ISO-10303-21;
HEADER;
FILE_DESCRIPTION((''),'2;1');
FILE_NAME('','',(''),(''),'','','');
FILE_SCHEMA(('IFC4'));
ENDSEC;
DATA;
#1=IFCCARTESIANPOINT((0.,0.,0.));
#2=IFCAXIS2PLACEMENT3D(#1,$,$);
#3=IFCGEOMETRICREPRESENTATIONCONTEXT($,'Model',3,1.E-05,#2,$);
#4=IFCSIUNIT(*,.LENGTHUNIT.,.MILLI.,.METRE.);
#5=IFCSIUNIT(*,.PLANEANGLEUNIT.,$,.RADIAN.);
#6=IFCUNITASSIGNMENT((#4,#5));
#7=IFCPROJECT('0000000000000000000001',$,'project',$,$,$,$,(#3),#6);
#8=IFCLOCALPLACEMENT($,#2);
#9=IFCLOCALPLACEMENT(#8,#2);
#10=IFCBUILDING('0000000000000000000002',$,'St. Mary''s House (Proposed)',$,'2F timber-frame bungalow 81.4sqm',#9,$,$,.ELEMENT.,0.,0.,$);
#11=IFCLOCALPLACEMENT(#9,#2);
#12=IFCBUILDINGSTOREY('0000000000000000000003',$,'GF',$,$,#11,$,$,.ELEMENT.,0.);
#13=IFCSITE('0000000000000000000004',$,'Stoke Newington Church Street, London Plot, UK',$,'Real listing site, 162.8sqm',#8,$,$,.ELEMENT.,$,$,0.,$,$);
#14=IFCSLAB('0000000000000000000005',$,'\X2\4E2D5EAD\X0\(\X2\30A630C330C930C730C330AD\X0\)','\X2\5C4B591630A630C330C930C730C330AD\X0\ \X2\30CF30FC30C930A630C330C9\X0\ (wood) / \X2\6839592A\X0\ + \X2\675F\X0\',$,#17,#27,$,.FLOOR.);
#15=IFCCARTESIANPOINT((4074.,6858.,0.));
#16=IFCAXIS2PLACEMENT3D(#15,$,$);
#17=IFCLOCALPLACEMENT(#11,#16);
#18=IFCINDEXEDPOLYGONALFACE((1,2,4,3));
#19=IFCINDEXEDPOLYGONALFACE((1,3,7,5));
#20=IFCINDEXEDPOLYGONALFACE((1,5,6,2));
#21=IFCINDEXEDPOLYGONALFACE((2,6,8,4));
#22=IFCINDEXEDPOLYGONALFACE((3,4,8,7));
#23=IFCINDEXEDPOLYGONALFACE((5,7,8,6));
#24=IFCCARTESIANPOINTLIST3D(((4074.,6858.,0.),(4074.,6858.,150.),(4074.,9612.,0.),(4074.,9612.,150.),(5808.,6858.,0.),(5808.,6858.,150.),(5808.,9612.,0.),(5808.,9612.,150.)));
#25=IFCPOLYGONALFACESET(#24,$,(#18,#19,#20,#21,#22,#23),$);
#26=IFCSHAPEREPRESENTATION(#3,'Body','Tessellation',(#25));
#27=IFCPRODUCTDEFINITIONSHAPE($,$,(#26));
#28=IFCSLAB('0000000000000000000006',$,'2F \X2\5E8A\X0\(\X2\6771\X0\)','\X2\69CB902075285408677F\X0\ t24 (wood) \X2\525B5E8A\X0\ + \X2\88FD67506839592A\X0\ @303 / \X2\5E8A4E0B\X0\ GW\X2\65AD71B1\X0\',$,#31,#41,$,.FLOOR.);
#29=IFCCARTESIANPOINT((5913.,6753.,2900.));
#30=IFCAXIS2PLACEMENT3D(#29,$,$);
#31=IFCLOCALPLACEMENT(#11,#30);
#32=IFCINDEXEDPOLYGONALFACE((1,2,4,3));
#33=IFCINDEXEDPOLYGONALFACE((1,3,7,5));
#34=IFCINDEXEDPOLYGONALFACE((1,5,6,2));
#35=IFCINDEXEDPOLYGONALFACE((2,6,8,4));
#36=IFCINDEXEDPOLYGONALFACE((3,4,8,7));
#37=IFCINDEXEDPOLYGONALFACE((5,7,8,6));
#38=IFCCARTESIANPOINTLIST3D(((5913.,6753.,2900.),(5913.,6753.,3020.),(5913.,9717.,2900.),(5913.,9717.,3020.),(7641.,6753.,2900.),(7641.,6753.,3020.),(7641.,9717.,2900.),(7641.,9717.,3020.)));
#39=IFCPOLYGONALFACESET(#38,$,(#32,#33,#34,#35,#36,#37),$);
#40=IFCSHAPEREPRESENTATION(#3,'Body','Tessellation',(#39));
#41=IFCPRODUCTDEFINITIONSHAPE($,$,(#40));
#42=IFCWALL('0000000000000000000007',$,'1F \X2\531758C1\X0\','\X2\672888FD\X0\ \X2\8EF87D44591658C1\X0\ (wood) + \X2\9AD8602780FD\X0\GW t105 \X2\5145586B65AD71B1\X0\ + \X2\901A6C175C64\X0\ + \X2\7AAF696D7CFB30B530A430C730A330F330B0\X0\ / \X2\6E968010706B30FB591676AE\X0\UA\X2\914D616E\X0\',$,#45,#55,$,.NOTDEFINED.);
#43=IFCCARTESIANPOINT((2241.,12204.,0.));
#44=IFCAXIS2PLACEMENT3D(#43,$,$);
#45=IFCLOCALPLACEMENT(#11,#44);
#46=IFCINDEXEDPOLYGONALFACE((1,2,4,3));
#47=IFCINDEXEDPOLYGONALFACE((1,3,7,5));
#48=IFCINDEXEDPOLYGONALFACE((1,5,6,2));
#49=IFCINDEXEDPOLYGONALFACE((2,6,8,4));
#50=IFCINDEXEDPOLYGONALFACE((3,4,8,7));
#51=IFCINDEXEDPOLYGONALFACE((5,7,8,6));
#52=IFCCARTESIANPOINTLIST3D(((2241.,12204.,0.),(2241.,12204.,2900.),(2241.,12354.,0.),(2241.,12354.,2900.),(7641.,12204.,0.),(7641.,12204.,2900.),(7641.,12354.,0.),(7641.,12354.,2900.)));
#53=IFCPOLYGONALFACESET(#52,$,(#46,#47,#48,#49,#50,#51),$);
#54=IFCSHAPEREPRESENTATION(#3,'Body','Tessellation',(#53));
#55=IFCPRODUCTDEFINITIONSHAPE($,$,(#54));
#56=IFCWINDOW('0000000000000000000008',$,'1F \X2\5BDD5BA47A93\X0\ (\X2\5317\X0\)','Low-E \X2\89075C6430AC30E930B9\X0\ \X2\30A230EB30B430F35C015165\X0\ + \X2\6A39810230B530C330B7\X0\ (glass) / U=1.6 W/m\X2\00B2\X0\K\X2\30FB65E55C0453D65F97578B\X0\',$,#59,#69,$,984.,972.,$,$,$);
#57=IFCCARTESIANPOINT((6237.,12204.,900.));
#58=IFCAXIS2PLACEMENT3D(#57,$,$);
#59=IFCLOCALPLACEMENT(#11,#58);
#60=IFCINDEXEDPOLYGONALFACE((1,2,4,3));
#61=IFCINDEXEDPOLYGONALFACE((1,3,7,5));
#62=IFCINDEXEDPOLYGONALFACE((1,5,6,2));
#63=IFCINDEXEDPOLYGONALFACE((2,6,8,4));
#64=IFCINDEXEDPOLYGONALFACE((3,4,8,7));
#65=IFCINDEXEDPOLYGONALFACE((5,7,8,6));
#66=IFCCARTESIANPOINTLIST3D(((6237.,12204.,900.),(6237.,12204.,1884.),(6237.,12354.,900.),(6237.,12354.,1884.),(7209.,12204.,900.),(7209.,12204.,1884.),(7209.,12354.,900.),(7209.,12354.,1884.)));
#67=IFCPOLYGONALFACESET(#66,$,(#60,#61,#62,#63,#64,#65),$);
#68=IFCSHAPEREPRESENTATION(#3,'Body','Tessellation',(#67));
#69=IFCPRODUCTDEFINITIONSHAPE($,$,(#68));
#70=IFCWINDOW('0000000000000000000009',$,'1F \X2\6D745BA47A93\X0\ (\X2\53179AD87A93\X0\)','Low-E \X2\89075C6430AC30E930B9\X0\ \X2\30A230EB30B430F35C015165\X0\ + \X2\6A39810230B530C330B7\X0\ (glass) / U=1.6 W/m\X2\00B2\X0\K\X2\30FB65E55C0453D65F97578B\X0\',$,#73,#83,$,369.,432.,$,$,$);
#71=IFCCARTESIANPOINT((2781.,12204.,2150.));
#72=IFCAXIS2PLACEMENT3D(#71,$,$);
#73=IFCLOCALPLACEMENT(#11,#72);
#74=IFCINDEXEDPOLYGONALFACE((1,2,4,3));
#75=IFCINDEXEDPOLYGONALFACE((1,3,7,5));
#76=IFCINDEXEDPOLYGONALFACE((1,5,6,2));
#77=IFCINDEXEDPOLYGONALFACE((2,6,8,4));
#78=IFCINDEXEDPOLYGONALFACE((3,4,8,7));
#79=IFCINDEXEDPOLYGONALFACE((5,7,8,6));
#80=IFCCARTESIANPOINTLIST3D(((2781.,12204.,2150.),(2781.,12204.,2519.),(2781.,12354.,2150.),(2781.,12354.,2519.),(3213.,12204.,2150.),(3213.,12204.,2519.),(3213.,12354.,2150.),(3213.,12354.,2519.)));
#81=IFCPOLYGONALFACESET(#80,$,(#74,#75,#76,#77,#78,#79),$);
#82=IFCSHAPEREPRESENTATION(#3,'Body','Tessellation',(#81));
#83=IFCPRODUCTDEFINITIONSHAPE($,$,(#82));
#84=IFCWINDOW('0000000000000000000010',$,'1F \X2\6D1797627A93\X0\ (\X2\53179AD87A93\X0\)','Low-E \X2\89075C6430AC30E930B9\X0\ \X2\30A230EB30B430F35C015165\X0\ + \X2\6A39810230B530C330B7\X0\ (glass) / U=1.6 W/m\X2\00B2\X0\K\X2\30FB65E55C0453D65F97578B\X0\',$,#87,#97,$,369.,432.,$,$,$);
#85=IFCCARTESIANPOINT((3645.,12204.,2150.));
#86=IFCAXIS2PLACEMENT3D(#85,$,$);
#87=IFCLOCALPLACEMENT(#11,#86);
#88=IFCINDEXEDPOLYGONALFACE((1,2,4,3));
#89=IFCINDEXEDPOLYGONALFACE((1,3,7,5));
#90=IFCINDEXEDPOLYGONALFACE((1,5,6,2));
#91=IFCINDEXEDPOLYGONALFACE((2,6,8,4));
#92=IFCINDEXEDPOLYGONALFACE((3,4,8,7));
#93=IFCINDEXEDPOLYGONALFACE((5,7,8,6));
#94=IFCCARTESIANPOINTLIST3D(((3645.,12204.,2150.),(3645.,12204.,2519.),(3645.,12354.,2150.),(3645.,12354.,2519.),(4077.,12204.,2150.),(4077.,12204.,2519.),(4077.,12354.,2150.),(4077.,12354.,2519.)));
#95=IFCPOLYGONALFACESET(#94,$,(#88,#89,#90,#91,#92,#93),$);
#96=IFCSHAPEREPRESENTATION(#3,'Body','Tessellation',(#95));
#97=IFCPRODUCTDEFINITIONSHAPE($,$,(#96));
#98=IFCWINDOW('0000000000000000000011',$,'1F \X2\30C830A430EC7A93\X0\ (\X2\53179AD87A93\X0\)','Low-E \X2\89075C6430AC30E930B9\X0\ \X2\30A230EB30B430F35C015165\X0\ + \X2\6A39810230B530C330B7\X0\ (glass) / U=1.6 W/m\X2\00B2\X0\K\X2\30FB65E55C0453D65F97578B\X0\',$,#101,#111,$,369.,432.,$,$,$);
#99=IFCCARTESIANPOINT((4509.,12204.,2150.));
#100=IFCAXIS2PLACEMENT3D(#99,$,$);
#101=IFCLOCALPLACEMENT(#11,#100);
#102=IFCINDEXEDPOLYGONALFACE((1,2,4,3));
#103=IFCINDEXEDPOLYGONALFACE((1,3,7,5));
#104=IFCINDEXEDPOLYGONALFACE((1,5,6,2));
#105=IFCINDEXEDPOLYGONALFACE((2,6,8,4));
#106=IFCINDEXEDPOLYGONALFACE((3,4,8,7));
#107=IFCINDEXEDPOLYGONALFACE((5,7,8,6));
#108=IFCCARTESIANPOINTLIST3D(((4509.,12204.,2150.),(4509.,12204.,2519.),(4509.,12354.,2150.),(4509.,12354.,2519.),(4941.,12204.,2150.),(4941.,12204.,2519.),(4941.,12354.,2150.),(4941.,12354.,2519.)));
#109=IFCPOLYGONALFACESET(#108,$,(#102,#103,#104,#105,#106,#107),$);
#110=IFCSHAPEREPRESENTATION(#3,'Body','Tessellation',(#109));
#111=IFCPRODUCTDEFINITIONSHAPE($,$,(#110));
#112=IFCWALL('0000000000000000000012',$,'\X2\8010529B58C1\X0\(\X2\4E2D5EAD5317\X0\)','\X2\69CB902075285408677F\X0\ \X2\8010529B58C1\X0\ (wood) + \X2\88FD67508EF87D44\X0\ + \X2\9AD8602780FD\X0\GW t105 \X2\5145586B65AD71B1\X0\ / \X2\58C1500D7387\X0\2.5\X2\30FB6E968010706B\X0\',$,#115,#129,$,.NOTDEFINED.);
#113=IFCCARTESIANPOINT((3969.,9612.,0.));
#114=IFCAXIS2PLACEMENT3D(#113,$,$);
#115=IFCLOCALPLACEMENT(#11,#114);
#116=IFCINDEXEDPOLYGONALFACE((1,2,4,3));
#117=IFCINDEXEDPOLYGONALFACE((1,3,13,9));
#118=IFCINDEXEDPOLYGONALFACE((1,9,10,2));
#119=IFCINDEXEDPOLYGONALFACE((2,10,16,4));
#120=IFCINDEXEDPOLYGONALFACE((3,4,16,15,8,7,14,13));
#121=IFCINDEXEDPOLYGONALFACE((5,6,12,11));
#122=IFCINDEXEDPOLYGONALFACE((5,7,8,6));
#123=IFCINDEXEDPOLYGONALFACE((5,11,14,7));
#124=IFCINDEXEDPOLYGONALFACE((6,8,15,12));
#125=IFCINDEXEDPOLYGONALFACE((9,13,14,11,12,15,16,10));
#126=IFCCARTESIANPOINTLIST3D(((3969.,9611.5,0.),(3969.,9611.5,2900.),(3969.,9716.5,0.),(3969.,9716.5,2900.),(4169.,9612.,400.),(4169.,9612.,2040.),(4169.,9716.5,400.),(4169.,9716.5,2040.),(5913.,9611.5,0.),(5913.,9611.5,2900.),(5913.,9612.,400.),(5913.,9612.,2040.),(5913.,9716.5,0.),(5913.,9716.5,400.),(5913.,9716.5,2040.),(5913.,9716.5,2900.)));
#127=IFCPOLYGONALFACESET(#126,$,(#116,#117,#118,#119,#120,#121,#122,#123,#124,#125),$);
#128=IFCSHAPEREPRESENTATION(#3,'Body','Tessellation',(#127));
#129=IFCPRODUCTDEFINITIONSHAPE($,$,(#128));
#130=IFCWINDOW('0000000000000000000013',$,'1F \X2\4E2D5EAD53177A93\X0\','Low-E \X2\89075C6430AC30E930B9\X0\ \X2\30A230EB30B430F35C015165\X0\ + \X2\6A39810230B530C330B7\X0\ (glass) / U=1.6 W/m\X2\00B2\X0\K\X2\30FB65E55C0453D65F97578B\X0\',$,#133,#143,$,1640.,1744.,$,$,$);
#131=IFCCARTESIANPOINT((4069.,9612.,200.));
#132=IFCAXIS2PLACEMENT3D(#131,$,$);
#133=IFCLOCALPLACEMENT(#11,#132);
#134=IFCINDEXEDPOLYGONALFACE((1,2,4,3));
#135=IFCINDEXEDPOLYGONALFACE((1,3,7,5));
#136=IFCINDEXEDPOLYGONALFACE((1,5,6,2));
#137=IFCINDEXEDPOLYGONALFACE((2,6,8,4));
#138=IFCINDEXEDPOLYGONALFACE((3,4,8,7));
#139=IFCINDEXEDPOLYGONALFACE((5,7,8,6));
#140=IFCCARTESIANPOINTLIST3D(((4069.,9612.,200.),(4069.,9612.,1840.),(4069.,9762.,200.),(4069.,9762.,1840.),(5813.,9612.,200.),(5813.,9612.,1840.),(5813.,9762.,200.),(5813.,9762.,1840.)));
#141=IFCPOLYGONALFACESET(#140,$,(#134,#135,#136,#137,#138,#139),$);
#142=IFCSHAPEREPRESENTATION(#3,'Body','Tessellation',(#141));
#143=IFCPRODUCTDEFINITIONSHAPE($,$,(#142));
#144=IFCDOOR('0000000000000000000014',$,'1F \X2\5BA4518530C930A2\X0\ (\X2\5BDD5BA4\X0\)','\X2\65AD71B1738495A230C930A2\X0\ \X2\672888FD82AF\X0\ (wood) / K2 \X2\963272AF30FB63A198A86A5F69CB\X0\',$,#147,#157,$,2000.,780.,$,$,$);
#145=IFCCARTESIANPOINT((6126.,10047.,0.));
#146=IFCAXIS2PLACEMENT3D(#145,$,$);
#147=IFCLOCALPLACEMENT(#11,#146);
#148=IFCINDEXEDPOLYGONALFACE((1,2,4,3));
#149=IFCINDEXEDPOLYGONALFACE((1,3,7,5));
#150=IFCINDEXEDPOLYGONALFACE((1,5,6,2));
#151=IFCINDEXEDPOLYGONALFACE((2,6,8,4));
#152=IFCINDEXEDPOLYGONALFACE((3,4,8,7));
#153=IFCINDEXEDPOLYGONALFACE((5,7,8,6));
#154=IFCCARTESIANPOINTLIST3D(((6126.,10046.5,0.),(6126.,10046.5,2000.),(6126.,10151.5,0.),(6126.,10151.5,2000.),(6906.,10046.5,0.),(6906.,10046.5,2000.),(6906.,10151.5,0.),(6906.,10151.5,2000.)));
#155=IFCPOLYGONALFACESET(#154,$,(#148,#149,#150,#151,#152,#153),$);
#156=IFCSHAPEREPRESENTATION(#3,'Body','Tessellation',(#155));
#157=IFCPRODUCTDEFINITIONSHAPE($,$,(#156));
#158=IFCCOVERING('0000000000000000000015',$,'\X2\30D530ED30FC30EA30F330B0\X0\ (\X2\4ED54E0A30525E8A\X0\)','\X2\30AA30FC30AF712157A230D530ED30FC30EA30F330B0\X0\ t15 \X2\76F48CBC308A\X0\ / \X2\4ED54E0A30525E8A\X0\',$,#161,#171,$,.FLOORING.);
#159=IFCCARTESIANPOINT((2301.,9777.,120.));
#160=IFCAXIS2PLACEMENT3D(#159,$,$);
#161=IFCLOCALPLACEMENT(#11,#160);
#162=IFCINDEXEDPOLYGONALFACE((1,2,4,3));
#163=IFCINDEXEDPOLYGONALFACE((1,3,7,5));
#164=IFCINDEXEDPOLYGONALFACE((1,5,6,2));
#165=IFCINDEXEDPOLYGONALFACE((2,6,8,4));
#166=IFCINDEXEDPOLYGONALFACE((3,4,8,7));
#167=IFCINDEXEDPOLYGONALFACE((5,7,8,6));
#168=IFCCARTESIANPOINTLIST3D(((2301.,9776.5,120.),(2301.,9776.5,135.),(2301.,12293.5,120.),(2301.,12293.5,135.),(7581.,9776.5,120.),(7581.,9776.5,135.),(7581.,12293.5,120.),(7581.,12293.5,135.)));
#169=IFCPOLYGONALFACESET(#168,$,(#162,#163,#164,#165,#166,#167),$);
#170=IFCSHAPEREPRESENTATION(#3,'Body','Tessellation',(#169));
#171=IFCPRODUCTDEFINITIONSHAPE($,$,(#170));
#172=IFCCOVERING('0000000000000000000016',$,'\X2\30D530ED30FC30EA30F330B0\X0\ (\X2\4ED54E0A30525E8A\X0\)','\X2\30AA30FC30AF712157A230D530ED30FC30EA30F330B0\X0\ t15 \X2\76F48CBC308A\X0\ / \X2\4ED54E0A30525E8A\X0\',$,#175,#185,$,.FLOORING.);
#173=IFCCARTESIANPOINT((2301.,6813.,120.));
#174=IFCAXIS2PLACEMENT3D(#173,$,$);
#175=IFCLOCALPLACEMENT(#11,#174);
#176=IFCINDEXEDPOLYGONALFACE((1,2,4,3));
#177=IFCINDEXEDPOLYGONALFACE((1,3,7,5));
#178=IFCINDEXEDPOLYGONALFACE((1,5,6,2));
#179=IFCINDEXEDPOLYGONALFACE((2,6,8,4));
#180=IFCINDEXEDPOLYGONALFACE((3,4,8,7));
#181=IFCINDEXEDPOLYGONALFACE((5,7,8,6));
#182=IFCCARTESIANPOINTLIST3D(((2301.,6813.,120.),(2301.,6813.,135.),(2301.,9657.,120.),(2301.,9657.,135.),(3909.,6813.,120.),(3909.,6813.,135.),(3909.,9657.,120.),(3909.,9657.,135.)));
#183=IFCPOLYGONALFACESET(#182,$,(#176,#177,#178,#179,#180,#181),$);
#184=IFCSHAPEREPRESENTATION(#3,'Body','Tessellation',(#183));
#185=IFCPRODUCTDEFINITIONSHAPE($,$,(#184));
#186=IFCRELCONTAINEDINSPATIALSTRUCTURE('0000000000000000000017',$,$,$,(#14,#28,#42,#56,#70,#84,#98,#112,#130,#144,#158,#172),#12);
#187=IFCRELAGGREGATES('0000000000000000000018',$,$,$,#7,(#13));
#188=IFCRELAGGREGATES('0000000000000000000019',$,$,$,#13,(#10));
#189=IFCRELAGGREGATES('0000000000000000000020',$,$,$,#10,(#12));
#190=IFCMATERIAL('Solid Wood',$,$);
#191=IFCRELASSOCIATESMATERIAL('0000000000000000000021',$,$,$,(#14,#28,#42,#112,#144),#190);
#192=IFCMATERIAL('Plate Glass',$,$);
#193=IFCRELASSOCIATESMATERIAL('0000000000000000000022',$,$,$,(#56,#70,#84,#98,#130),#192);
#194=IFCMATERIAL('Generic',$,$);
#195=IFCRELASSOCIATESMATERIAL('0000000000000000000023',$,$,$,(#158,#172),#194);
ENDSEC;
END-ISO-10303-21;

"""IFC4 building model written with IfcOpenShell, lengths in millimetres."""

from ifc_helpers import new_model, si_unit, frame, frame_2d, origin, place, context, project, spatial, rectangle, extrude, material, element, fill, save


model = new_model("IFC4")

# Units and contexts
model_context = context("Model", 3, precision=1e-05, world=origin())
ifc_project = project(units=[si_unit("LENGTHUNIT", "METRE", prefix="MILLI"), si_unit("PLANEANGLEUNIT", "RADIAN")], contexts=[model_context])

# Site, building, storey
site_placement = place(None, origin())
site = spatial("IfcSite", under=ifc_project, at=site_placement, Name="Stoke Newington Church Street, London Plot, UK", ObjectType="Real listing site, 162.8sqm", CompositionType="ELEMENT", RefElevation=0.0)
building_placement = place(site_placement, origin())
building = spatial("IfcBuilding", under=site, at=building_placement, Name="St. Mary's House (Proposed)", ObjectType="2F timber-frame bungalow 81.4sqm", CompositionType="ELEMENT", ElevationOfRefHeight=0.0, ElevationOfTerrain=0.0)
storey_placement = place(building_placement, origin())
storey = spatial("IfcBuildingStorey", under=building, at=storey_placement, Name="GF", CompositionType="ELEMENT", Elevation=0.0)

# Slabs
ifc_material_1 = material(Name="Solid Wood")
slab_1_placement = place(storey_placement, frame((4074.0, 6858.0, 0.0)))
element("IfcSlab", 1, at=slab_1_placement, inside=storey, material=ifc_material_1, Name="中庭(ウッドデッキ)", Description="屋外ウッドデッキ ハードウッド (wood) / 根太 + 束", PredefinedType="FLOOR", context=model_context, shape_type="SweptSolid", body=[
    extrude(rectangle(XDim=1734.0, YDim=2754.0, at=frame_2d((867.0, 1377.0))), frame((4074.0, 6858.0, 0.0)), (0.0, 0.0, 1.0), 150.0),
])
slab_2_placement = place(storey_placement, frame((5913.0, 6753.0, 2900.0)))
element("IfcSlab", 2, at=slab_2_placement, inside=storey, material=ifc_material_1, Name="2F 床(東)", Description="構造用合板 t24 (wood) 剛床 + 製材根太 @303 / 床下 GW断熱", PredefinedType="FLOOR", context=model_context, shape_type="SweptSolid", body=[
    extrude(rectangle(XDim=1728.0, YDim=2964.0, at=frame_2d((864.0, 1482.0))), frame((5913.0, 6753.0, 2900.0)), (0.0, 0.0, 1.0), 120.0),
])

# Wall, openings, windows
wall_1_placement = place(storey_placement, frame((2241.0, 12204.0, 0.0)))
wall_1 = element("IfcWall", 3, at=wall_1_placement, inside=storey, material=ifc_material_1, Name="1F 北壁", Description="木製 軸組外壁 (wood) + 高性能GW t105 充填断熱 + 通気層 + 窯業系サイディング / 準耐火・外皮UA配慮", PredefinedType="NOTDEFINED", context=model_context, shape_type="SweptSolid", body=[
    extrude(rectangle(XDim=5400.0, YDim=150.0, at=frame_2d((2700.0, 75.0))), frame((2241.0, 12204.0, 0.0)), (0.0, 0.0, 1.0), 2900.0),
])
opening_1_placement = place(storey_placement, frame((6237.0, 12204.0, 900.0)))
opening_1 = element("IfcOpeningElement", 4, at=opening_1_placement, cuts=wall_1, PredefinedType="NOTDEFINED", context=model_context, shape_type="SweptSolid", body=[
    extrude(rectangle(XDim=972.0, YDim=150.0, at=frame_2d((486.0, 75.0))), frame((6237.0, 12204.0, 900.0)), (0.0, 0.0, 1.0), 984.0),
])
opening_2_placement = place(storey_placement, frame((2781.0, 12204.0, 2150.0)))
opening_2 = element("IfcOpeningElement", 5, at=opening_2_placement, cuts=wall_1, PredefinedType="NOTDEFINED", context=model_context, shape_type="SweptSolid", body=[
    extrude(rectangle(XDim=432.0, YDim=150.0, at=frame_2d((216.0, 75.0))), frame((2781.0, 12204.0, 2150.0)), (0.0, 0.0, 1.0), 369.0),
])
opening_3_placement = place(storey_placement, frame((3645.0, 12204.0, 2150.0)))
opening_3 = element("IfcOpeningElement", 6, at=opening_3_placement, cuts=wall_1, PredefinedType="NOTDEFINED", context=model_context, shape_type="SweptSolid", body=[
    extrude(rectangle(XDim=432.0, YDim=150.0, at=frame_2d((216.0, 75.0))), frame((3645.0, 12204.0, 2150.0)), (0.0, 0.0, 1.0), 369.0),
])
opening_4_placement = place(storey_placement, frame((4509.0, 12204.0, 2150.0)))
opening_4 = element("IfcOpeningElement", 7, at=opening_4_placement, cuts=wall_1, PredefinedType="NOTDEFINED", context=model_context, shape_type="SweptSolid", body=[
    extrude(rectangle(XDim=432.0, YDim=150.0, at=frame_2d((216.0, 75.0))), frame((4509.0, 12204.0, 2150.0)), (0.0, 0.0, 1.0), 369.0),
])
ifc_material_2 = material(Name="Plate Glass")
window_1_placement = place(storey_placement, frame((6237.0, 12204.0, 900.0)))
window_1 = element("IfcWindow", 8, at=window_1_placement, inside=storey, material=ifc_material_2, Name="1F 寝室窓 (北)", Description="Low-E 複層ガラス アルゴン封入 + 樹脂サッシ (glass) / U=1.6 W/m²K・日射取得型", OverallHeight=984.0, OverallWidth=972.0, context=model_context, shape_type="SweptSolid", body=[
    extrude(rectangle(XDim=972.0, YDim=150.0, at=frame_2d((486.0, 75.0))), frame((6237.0, 12204.0, 900.0)), (0.0, 0.0, 1.0), 984.0),
])
fill(opening_1, window_1)
window_2_placement = place(storey_placement, frame((2781.0, 12204.0, 2150.0)))
window_2 = element("IfcWindow", 9, at=window_2_placement, inside=storey, material=ifc_material_2, Name="1F 浴室窓 (北高窓)", Description="Low-E 複層ガラス アルゴン封入 + 樹脂サッシ (glass) / U=1.6 W/m²K・日射取得型", OverallHeight=369.0, OverallWidth=432.0, context=model_context, shape_type="SweptSolid", body=[
    extrude(rectangle(XDim=432.0, YDim=150.0, at=frame_2d((216.0, 75.0))), frame((2781.0, 12204.0, 2150.0)), (0.0, 0.0, 1.0), 369.0),
])
fill(opening_2, window_2)
window_3_placement = place(storey_placement, frame((3645.0, 12204.0, 2150.0)))
window_3 = element("IfcWindow", 10, at=window_3_placement, inside=storey, material=ifc_material_2, Name="1F 洗面窓 (北高窓)", Description="Low-E 複層ガラス アルゴン封入 + 樹脂サッシ (glass) / U=1.6 W/m²K・日射取得型", OverallHeight=369.0, OverallWidth=432.0, context=model_context, shape_type="SweptSolid", body=[
    extrude(rectangle(XDim=432.0, YDim=150.0, at=frame_2d((216.0, 75.0))), frame((3645.0, 12204.0, 2150.0)), (0.0, 0.0, 1.0), 369.0),
])
fill(opening_3, window_3)
window_4_placement = place(storey_placement, frame((4509.0, 12204.0, 2150.0)))
window_4 = element("IfcWindow", 11, at=window_4_placement, inside=storey, material=ifc_material_2, Name="1F トイレ窓 (北高窓)", Description="Low-E 複層ガラス アルゴン封入 + 樹脂サッシ (glass) / U=1.6 W/m²K・日射取得型", OverallHeight=369.0, OverallWidth=432.0, context=model_context, shape_type="SweptSolid", body=[
    extrude(rectangle(XDim=432.0, YDim=150.0, at=frame_2d((216.0, 75.0))), frame((4509.0, 12204.0, 2150.0)), (0.0, 0.0, 1.0), 369.0),
])
fill(opening_4, window_4)

# Wall, opening, window
wall_2_placement = place(storey_placement, frame((3969.0, 9612.0, 0.0)))
wall_2 = element("IfcWall", 12, at=wall_2_placement, inside=storey, material=ifc_material_1, Name="耐力壁(中庭北)", Description="構造用合板 耐力壁 (wood) + 製材軸組 + 高性能GW t105 充填断熱 / 壁倍率2.5・準耐火", PredefinedType="NOTDEFINED", context=model_context, shape_type="SweptSolid", body=[
    extrude(rectangle(XDim=1944.0, YDim=105.0, at=frame_2d((972.0, 52.0))), frame((3969.0, 9612.0, 0.0)), (0.0, 0.0, 1.0), 2900.0),
])
opening_5_placement = place(storey_placement, frame((4069.0, 9612.0, 200.0)))
opening_5 = element("IfcOpeningElement", 13, at=opening_5_placement, cuts=wall_2, PredefinedType="NOTDEFINED", context=model_context, shape_type="SweptSolid", body=[
    extrude(rectangle(XDim=1744.0, YDim=150.0, at=frame_2d((872.0, 75.0))), frame((4069.0, 9612.0, 200.0)), (0.0, 0.0, 1.0), 1640.0),
])
window_5_placement = place(storey_placement, frame((4069.0, 9612.0, 200.0)))
window_5 = element("IfcWindow", 14, at=window_5_placement, inside=storey, material=ifc_material_2, Name="1F 中庭北窓", Description="Low-E 複層ガラス アルゴン封入 + 樹脂サッシ (glass) / U=1.6 W/m²K・日射取得型", OverallHeight=1640.0, OverallWidth=1744.0, context=model_context, shape_type="SweptSolid", body=[
    extrude(rectangle(XDim=1744.0, YDim=150.0, at=frame_2d((872.0, 75.0))), frame((4069.0, 9612.0, 200.0)), (0.0, 0.0, 1.0), 1640.0),
])
fill(opening_5, window_5)

# Door
door_1_placement = place(storey_placement, frame((6126.0, 10047.0, 0.0)))
element("IfcDoor", 15, at=door_1_placement, inside=storey, material=ifc_material_1, Name="1F 室内ドア (寝室)", Description="断熱玄関ドア 木製芯 (wood) / K2 防犯・採風機構", OverallHeight=2000.0, OverallWidth=780.0, context=model_context, shape_type="SweptSolid", body=[
    extrude(rectangle(XDim=780.0, YDim=105.0, at=frame_2d((390.0, 52.0))), frame((6126.0, 10047.0, 0.0)), (0.0, 0.0, 1.0), 2000.0),
])

# Coverings
ifc_material_3 = material(Name="Generic")
covering_1_placement = place(storey_placement, frame((2301.0, 9777.0, 120.0)))
element("IfcCovering", 16, at=covering_1_placement, inside=storey, material=ifc_material_3, Name="フローリング (仕上げ床)", Description="オーク無垢フローリング t15 直貼り / 仕上げ床", PredefinedType="FLOORING", context=model_context, shape_type="SweptSolid", body=[
    extrude(rectangle(XDim=5280.0, YDim=2517.0, at=frame_2d((2640.0, 1258.0))), frame((2301.0, 9777.0, 120.0)), (0.0, 0.0, 1.0), 15.0),
])
covering_2_placement = place(storey_placement, frame((2301.0, 6813.0, 120.0)))
element("IfcCovering", 17, at=covering_2_placement, inside=storey, material=ifc_material_3, Name="フローリング (仕上げ床)", Description="オーク無垢フローリング t15 直貼り / 仕上げ床", PredefinedType="FLOORING", context=model_context, shape_type="SweptSolid", body=[
    extrude(rectangle(XDim=1608.0, YDim=2844.0, at=frame_2d((804.0, 1422.0))), frame((2301.0, 6813.0, 120.0)), (0.0, 0.0, 1.0), 15.0),
])

save(model, "model.ifc")
